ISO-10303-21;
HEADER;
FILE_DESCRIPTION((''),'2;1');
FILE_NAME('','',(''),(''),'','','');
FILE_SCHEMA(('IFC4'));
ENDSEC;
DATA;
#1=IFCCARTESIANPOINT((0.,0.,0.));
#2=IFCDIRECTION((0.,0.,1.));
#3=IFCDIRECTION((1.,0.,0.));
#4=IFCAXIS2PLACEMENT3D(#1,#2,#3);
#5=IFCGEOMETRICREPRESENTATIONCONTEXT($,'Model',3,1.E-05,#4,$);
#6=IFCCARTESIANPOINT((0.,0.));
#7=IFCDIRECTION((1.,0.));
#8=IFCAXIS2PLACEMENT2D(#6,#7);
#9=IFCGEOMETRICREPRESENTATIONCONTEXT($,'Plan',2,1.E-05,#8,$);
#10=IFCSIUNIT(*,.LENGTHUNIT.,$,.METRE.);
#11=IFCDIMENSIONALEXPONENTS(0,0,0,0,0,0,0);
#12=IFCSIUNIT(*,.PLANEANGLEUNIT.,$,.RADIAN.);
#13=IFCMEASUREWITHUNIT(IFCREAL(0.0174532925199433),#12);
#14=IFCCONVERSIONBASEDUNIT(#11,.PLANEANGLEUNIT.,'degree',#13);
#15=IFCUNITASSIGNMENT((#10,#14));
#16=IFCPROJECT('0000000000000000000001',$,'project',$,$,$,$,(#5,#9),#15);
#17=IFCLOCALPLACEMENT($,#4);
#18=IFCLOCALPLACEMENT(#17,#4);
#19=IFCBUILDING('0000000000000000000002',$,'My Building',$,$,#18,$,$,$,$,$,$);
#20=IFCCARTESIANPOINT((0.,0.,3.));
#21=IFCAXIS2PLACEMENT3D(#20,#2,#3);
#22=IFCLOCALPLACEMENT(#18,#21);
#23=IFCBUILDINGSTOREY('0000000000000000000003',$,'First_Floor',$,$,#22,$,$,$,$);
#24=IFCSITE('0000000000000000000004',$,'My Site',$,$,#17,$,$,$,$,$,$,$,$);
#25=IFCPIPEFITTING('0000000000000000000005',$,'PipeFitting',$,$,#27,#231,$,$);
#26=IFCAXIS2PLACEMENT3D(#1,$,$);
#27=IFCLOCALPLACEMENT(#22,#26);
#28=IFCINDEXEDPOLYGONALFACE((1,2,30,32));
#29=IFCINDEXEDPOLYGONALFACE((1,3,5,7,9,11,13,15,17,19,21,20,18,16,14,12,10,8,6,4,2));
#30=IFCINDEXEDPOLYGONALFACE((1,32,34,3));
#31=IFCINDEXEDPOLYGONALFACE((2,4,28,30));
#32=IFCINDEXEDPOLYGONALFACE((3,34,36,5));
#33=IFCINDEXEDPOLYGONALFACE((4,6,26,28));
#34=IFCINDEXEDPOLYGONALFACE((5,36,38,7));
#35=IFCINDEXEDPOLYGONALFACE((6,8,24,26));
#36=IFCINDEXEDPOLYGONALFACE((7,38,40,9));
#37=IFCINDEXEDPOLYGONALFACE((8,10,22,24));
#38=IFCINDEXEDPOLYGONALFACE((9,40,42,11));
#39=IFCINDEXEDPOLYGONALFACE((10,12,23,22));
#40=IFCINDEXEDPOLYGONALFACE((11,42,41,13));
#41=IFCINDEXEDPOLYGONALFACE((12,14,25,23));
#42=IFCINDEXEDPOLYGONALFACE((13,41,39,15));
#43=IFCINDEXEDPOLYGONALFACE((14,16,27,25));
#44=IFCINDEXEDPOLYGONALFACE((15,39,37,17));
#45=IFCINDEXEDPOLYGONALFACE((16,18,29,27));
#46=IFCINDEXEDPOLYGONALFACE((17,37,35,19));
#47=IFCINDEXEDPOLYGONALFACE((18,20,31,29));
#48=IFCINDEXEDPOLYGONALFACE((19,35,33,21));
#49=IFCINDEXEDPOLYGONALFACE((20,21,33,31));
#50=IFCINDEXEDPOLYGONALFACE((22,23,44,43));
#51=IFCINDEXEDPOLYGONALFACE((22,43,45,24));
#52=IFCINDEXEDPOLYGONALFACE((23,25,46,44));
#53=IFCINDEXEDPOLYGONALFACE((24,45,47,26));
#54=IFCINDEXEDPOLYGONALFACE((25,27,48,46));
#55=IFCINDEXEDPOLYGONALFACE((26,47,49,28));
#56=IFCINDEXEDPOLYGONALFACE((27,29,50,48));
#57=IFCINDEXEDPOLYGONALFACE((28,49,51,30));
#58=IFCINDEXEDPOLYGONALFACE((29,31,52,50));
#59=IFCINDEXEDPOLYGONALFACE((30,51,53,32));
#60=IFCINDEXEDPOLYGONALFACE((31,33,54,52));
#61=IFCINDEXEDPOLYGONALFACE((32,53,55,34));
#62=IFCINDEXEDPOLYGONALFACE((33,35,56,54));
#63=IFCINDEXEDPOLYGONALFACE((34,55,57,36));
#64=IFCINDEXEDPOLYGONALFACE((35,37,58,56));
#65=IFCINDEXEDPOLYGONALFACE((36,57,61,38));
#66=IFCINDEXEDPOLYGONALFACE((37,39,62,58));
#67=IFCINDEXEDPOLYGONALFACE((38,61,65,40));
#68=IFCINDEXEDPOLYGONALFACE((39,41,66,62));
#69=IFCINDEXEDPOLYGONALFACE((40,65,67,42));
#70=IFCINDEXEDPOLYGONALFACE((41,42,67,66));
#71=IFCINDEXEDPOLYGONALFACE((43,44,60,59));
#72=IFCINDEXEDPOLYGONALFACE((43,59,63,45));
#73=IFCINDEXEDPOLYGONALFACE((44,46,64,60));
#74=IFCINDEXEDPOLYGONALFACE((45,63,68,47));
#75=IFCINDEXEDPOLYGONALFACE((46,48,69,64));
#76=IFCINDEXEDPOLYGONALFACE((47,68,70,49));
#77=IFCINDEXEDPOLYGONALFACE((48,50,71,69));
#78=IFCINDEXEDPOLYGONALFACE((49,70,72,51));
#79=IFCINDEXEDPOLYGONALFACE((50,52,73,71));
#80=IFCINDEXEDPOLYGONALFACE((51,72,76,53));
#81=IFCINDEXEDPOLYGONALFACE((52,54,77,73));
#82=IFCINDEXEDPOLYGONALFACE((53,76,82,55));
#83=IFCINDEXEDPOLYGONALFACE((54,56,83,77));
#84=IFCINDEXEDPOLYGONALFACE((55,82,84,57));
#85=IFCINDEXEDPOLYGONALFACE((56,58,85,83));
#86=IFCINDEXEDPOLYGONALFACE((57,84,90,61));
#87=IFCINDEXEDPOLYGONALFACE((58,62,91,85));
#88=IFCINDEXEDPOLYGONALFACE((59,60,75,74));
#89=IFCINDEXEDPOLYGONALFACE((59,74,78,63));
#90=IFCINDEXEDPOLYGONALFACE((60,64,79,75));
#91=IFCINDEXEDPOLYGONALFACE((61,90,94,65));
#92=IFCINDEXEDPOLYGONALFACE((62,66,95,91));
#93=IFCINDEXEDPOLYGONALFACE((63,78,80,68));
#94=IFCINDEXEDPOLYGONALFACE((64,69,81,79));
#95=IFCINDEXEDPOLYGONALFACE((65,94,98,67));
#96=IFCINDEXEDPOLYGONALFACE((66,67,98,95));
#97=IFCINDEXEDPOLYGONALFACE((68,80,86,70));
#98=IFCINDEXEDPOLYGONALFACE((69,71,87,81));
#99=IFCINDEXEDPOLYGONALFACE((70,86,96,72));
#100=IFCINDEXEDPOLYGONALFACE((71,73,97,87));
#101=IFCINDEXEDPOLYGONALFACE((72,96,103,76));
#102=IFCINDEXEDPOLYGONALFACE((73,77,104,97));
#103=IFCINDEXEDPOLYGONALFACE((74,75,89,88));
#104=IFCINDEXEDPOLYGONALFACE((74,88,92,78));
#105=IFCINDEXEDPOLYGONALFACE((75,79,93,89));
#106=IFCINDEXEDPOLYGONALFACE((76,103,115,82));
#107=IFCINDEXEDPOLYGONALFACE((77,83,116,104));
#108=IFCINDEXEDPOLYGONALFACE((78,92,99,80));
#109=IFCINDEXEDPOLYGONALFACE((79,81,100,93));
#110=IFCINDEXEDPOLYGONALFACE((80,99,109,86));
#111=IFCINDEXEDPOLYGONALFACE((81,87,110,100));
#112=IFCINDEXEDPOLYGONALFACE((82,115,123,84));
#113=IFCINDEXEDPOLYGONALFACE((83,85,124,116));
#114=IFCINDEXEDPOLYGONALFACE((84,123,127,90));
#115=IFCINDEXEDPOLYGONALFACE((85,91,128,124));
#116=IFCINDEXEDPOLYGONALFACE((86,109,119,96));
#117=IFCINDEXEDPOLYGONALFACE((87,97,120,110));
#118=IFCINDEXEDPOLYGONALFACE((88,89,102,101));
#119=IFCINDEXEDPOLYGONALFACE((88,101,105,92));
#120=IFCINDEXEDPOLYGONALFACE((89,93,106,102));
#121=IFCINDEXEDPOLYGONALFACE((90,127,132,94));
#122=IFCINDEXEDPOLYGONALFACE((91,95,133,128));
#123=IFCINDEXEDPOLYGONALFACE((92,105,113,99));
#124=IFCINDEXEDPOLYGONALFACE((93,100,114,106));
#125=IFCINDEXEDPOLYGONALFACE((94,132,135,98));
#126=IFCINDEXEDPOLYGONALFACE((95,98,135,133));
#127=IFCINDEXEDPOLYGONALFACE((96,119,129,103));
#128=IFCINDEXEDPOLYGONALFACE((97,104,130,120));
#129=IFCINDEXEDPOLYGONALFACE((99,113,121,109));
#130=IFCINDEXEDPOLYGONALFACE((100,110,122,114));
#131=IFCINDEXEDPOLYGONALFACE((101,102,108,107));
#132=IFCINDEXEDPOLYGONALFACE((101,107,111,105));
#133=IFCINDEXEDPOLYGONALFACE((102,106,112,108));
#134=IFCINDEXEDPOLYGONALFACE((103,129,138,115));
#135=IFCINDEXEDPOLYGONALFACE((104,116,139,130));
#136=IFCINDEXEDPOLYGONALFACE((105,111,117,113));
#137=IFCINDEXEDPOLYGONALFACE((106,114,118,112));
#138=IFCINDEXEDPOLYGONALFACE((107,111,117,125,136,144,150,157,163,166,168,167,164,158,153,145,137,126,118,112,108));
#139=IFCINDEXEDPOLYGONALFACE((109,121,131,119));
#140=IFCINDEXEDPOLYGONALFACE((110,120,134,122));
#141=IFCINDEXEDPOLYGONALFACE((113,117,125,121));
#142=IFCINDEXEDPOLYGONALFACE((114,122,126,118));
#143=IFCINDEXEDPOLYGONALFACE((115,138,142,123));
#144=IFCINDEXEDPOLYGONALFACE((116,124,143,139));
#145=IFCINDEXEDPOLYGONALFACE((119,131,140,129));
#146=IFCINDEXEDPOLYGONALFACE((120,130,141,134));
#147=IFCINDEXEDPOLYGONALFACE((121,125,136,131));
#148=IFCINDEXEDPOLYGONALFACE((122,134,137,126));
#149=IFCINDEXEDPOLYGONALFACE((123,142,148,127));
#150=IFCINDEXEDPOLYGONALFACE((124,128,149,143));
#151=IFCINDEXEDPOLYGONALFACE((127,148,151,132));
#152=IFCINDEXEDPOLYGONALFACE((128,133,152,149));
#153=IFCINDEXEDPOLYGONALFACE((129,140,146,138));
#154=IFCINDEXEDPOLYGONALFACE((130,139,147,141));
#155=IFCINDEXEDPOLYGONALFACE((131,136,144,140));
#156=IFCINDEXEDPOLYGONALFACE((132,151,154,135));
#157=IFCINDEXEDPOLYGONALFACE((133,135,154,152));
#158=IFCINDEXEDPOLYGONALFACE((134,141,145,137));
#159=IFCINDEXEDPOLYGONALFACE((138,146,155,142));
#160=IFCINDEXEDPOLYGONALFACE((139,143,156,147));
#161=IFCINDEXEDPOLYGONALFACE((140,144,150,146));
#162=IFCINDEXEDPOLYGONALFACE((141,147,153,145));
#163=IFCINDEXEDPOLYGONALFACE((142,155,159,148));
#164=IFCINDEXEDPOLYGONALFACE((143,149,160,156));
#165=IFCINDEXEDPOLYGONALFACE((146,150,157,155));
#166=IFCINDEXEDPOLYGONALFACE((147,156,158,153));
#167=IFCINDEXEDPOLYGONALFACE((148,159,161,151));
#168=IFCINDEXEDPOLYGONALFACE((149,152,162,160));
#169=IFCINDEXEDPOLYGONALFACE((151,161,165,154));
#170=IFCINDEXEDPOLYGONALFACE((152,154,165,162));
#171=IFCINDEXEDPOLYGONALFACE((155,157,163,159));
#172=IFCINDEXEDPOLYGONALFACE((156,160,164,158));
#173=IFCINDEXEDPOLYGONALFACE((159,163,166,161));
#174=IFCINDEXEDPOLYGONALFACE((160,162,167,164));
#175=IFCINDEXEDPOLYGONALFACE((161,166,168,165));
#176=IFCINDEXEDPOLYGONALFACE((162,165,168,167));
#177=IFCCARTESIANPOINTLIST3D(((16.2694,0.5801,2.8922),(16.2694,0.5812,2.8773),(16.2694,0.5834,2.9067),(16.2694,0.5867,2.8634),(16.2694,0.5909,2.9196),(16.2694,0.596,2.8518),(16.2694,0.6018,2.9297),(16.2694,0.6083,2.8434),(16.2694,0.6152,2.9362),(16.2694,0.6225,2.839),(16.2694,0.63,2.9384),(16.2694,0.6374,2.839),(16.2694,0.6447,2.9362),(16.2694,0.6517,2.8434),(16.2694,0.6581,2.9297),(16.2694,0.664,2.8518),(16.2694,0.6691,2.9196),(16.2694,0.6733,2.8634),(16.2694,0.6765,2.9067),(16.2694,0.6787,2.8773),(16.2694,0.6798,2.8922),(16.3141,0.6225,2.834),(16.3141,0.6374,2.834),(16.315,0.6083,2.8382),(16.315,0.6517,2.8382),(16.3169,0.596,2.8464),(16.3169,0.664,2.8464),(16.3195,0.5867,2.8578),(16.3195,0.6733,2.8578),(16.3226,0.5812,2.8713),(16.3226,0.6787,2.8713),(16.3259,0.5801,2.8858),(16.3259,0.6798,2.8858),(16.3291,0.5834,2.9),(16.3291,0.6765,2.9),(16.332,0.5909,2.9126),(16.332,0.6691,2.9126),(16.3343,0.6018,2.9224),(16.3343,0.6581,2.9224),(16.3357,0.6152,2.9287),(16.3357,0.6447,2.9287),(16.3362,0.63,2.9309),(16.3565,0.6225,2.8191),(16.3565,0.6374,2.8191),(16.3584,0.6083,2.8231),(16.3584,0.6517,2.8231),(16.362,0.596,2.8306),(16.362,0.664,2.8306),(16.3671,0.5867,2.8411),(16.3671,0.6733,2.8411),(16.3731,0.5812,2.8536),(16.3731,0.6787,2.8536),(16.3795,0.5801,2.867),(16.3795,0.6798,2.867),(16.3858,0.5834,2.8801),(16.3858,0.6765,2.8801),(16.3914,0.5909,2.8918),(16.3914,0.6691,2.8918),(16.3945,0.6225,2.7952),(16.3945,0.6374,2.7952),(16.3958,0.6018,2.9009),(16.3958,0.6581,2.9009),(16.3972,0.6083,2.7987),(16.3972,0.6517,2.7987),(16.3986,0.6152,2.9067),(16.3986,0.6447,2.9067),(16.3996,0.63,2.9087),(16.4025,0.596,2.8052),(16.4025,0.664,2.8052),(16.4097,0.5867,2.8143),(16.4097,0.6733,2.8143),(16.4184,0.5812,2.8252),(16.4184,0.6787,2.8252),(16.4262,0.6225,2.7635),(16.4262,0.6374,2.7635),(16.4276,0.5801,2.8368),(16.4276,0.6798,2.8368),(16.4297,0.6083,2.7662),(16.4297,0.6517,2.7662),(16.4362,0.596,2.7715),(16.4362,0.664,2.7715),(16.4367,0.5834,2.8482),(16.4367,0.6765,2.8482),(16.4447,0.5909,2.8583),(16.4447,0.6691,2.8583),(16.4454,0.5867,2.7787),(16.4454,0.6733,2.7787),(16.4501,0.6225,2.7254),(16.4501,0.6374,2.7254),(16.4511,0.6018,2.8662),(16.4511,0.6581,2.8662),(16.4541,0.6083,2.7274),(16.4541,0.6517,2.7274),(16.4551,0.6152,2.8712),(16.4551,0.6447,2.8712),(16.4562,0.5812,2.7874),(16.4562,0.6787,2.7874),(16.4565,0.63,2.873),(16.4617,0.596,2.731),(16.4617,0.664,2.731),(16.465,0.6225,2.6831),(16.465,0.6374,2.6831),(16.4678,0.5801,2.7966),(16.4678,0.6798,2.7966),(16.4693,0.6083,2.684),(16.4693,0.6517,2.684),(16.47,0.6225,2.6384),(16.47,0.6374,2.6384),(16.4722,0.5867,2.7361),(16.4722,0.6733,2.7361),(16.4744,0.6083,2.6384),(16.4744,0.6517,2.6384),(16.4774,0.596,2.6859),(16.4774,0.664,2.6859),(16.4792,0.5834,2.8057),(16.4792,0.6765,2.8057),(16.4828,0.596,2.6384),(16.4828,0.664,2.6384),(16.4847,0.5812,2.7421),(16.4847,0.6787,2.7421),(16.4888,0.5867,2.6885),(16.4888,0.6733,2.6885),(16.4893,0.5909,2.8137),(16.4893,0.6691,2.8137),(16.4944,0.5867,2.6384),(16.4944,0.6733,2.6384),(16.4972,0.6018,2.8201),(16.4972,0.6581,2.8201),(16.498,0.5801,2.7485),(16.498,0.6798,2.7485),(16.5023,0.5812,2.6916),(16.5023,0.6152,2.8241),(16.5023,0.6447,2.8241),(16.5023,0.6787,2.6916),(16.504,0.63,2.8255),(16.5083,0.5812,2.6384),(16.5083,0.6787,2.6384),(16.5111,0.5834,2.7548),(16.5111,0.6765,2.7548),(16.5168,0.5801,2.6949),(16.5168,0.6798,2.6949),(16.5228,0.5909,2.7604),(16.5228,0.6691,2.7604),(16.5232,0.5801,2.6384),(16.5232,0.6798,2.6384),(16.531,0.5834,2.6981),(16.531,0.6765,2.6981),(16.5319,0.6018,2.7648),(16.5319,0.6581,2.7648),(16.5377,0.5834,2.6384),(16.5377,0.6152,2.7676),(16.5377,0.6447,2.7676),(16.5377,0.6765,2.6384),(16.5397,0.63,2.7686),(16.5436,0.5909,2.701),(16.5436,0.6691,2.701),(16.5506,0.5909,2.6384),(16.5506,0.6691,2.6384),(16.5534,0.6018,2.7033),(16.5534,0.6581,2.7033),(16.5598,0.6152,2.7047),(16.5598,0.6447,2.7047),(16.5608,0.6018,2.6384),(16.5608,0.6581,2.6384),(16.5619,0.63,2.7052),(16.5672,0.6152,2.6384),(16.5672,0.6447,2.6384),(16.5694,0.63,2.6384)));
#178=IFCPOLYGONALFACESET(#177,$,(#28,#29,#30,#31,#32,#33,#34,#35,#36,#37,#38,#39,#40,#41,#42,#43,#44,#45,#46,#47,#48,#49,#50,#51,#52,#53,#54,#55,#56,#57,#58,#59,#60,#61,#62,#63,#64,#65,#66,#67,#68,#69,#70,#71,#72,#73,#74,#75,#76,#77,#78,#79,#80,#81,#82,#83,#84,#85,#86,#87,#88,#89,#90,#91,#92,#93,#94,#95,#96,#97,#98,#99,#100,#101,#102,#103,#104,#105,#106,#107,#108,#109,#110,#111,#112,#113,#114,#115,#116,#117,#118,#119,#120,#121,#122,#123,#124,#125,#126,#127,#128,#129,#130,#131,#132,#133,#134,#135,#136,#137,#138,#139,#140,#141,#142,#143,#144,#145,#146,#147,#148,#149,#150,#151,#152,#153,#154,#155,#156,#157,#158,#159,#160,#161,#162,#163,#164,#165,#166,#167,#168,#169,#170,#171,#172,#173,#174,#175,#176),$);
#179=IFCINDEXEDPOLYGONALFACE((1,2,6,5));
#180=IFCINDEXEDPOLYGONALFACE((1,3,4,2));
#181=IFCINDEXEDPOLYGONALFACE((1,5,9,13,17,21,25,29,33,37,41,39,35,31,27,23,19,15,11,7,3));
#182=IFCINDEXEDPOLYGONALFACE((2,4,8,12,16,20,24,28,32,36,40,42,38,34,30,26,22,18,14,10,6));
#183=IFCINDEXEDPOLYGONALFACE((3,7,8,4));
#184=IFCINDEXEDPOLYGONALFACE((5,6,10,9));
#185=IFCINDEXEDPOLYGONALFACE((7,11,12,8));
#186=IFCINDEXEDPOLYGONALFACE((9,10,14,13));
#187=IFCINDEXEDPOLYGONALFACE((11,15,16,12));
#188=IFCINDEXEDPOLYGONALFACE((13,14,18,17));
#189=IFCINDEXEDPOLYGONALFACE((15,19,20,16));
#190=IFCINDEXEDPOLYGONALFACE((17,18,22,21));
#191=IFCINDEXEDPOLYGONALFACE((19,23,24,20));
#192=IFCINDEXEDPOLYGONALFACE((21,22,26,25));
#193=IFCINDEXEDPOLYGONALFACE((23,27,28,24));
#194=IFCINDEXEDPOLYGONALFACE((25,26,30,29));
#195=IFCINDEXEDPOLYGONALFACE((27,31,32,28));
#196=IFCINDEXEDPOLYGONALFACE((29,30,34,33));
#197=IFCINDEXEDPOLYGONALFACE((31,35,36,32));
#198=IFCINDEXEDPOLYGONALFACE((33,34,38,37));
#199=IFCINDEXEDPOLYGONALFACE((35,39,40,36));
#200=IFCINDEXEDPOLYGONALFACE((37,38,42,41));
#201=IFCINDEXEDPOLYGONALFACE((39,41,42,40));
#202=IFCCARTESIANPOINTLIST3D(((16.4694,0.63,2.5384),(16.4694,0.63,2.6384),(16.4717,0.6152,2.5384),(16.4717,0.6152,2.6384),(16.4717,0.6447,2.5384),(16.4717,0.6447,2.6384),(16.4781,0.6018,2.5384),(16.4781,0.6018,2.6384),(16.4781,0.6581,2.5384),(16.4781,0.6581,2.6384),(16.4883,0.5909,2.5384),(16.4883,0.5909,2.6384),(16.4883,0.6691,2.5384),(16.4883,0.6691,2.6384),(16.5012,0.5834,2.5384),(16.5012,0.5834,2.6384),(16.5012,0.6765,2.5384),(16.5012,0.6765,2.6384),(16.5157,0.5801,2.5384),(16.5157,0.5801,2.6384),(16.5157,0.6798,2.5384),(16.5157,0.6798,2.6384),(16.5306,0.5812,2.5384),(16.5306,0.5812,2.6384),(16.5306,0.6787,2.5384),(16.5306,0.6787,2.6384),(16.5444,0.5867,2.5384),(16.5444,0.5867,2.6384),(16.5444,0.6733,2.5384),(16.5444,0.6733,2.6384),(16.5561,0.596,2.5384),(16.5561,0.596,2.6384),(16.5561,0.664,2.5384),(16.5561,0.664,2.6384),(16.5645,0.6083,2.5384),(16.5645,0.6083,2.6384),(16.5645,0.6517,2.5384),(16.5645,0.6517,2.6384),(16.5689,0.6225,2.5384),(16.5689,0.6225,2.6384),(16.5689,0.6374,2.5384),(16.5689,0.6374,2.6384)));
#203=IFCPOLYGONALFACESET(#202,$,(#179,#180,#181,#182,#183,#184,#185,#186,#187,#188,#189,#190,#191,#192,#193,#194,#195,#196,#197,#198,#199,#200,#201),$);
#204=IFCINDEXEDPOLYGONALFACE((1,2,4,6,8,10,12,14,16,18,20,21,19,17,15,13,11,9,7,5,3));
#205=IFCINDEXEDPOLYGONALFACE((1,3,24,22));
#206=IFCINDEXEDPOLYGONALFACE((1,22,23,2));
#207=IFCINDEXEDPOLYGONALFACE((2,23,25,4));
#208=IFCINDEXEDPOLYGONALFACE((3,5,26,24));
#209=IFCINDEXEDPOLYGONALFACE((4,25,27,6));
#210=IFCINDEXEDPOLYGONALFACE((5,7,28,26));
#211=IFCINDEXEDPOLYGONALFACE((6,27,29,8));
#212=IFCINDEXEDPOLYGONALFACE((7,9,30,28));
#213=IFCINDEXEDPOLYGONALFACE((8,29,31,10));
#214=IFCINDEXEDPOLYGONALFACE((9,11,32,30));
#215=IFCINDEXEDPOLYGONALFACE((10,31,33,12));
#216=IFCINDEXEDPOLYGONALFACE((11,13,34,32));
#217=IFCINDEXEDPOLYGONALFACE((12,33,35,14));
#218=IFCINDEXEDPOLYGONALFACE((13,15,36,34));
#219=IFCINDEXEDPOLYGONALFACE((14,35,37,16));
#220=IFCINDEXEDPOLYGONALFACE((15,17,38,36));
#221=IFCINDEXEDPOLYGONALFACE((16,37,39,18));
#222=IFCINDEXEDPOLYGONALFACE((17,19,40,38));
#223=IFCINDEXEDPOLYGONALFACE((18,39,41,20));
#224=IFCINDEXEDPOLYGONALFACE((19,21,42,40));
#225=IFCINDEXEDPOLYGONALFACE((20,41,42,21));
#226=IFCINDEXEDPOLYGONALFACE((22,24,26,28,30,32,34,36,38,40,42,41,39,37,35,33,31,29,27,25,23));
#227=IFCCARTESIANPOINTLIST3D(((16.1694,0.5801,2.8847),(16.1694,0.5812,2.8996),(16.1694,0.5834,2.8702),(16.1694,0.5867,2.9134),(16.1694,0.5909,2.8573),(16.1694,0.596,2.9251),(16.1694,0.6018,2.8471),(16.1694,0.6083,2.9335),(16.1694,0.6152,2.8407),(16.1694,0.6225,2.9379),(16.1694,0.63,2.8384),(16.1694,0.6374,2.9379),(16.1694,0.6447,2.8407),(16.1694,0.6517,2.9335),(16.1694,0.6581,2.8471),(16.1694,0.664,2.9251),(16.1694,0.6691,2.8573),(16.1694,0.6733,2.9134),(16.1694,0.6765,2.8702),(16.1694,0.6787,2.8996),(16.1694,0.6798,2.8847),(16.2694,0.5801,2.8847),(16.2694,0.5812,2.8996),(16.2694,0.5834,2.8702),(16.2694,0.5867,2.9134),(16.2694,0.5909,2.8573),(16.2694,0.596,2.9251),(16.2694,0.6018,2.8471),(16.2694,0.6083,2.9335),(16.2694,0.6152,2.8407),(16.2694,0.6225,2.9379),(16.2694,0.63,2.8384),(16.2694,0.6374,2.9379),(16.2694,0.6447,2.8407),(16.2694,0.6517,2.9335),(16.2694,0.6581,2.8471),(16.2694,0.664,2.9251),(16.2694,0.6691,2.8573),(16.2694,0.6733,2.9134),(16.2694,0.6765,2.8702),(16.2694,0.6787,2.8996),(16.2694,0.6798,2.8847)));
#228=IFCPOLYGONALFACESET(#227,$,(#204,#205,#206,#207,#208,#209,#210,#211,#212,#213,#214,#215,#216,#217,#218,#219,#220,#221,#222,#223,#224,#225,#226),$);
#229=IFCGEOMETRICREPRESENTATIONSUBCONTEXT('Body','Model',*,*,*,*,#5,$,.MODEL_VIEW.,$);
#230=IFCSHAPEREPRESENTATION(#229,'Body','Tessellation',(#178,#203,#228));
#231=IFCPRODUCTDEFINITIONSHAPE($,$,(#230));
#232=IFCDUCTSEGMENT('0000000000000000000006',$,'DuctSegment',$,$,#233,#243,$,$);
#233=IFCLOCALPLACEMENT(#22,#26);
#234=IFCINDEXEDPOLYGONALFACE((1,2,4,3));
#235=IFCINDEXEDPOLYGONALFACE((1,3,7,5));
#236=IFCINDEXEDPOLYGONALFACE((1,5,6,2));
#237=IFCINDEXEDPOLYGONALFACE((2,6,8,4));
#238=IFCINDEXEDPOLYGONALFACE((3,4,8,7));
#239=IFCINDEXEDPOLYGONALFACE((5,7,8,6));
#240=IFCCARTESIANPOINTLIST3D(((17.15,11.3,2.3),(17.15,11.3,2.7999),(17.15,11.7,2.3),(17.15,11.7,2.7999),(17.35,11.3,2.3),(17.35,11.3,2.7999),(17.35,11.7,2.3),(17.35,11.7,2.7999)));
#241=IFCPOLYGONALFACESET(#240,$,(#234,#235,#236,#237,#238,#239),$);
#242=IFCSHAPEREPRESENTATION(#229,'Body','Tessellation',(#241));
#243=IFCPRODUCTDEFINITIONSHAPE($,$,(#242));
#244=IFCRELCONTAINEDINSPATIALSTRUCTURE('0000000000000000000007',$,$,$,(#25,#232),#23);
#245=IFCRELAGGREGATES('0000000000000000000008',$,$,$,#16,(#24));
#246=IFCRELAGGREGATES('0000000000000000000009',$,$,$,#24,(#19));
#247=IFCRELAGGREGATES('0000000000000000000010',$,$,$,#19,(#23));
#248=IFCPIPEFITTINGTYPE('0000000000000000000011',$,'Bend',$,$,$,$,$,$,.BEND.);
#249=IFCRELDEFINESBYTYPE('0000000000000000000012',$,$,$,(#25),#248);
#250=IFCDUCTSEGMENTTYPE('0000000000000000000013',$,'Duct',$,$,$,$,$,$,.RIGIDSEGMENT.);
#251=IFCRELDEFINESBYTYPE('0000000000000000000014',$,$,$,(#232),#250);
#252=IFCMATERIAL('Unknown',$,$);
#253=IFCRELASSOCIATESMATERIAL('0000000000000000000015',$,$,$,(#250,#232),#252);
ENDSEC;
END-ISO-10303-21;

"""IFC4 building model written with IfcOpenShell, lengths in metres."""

from ifc_helpers import new_model, entity, si_unit, converted_unit, frame, origin_with_axes, origin_2d_with_axis, place, context, subcontext, project, spatial, rectangle, circle, extrude, source, transform, mapped, material, material_profile, profile_set, profile_usage, type_object, type_shapes, element, save


model = new_model("IFC4")

# Units and contexts
model_context = context("Model", 3, precision=1e-05, world=origin_with_axes())
plan_context = context("Plan", 2, precision=1e-05, world=origin_2d_with_axis())
body_context = subcontext(model_context, "Body", "Model", "MODEL_VIEW")
ifc_project = project(units=[si_unit("LENGTHUNIT", "METRE"), converted_unit("PLANEANGLEUNIT", "degree", entity("IfcReal", 0.0174532925199433), si_unit("PLANEANGLEUNIT", "RADIAN"), dimensions=[0, 0, 0, 0, 0, 0, 0])], contexts=[model_context, plan_context])

# Site, building, storey
site_placement = place(None, origin_with_axes())
site = spatial("IfcSite", under=ifc_project, at=site_placement, Name="My Site")
building_placement = place(site_placement, origin_with_axes())
building = spatial("IfcBuilding", under=site, at=building_placement, Name="My Building")
storey_placement = place(building_placement, frame((0.0, 0.0, 3.0), z_axis=(0.0, 0.0, 1.0), x_axis=(1.0, 0.0, 0.0)))
storey = spatial("IfcBuildingStorey", under=building, at=storey_placement, Name="First_Floor")

# Shared definitions
ifc_material = material(Name="Unknown")

# Pipe fitting
pipe_fitting_type = type_object("IfcPipeFittingType", Name="Bend", PredefinedType="BEND")
shared_shape = source(origin_with_axes(), body_context, "Body", "SolidModel", [
    entity("IfcSweptDiskSolid", entity("IfcIndexedPolyCurve", entity("IfcCartesianPointList3D", [[0.0, 0.0, -0.1], [0.0732, 0.0, -0.2768], [0.25, 0.0, -0.35]]), [entity("IfcArcIndex", [1, 2, 3])]), 0.05),
    extrude(circle(Radius=0.05), origin_with_axes(), (0.0, 0.0, -1.0), 0.1),
    extrude(circle(Radius=0.05), frame((0.25, 0.0, -0.35), z_axis=(1.0, 0.0, 0.0), x_axis=(0.0, 0.0, 1.0)), (0.0, 0.0, 1.0), 0.1),
])
type_shapes(pipe_fitting_type, [shared_shape])
for number, where, z_axis, x_axis, name in (
    (1, (16.5194, 0.63, 2.5384), (0.000001, 0.0, -1.0), (-1.0, -0.000001, -0.000001), "PipeFitting"),
):
    element("IfcPipeFitting", number, at=place(storey_placement, frame(where, z_axis=z_axis, x_axis=x_axis)), inside=storey, type_object=pipe_fitting_type, Name=name, context=body_context, shape_type="MappedRepresentation", body=[
        mapped(shared_shape, transform((0.0, 0.0, 0.0), x_axis=(1.0, 0.0, 0.0), y_axis=(0.0, 1.0, 0.0), z_axis=(0.0, 0.0, 1.0), scale=1.0)),
    ])

# Duct segment
ifc_material_profile_1 = material_profile(ifc_material, rectangle(XDim=0.4, YDim=0.2))
ifc_profile_set_1 = profile_set([ifc_material_profile_1])
ifc_profile_usage_1 = profile_usage(ifc_profile_set_1, cardinal=5)
duct_segment_type = type_object("IfcDuctSegmentType", Name="Duct", PredefinedType="RIGIDSEGMENT", material=ifc_profile_set_1)
duct_segment_1_placement = place(storey_placement, frame((17.25, 11.5, 2.7999), z_axis=(0.0, 0.0, -1.0), x_axis=(0.0, 1.0, 0.0)))
element("IfcDuctSegment", 2, at=duct_segment_1_placement, inside=storey, type_object=duct_segment_type, material=ifc_profile_usage_1, Name="DuctSegment", context=body_context, shape_type="SweptSolid", body=[
    extrude(rectangle(XDim=0.4, YDim=0.2), origin_with_axes(), (0.0, 0.0, 1.0), 0.5),
])

save(model, "model.ifc")
